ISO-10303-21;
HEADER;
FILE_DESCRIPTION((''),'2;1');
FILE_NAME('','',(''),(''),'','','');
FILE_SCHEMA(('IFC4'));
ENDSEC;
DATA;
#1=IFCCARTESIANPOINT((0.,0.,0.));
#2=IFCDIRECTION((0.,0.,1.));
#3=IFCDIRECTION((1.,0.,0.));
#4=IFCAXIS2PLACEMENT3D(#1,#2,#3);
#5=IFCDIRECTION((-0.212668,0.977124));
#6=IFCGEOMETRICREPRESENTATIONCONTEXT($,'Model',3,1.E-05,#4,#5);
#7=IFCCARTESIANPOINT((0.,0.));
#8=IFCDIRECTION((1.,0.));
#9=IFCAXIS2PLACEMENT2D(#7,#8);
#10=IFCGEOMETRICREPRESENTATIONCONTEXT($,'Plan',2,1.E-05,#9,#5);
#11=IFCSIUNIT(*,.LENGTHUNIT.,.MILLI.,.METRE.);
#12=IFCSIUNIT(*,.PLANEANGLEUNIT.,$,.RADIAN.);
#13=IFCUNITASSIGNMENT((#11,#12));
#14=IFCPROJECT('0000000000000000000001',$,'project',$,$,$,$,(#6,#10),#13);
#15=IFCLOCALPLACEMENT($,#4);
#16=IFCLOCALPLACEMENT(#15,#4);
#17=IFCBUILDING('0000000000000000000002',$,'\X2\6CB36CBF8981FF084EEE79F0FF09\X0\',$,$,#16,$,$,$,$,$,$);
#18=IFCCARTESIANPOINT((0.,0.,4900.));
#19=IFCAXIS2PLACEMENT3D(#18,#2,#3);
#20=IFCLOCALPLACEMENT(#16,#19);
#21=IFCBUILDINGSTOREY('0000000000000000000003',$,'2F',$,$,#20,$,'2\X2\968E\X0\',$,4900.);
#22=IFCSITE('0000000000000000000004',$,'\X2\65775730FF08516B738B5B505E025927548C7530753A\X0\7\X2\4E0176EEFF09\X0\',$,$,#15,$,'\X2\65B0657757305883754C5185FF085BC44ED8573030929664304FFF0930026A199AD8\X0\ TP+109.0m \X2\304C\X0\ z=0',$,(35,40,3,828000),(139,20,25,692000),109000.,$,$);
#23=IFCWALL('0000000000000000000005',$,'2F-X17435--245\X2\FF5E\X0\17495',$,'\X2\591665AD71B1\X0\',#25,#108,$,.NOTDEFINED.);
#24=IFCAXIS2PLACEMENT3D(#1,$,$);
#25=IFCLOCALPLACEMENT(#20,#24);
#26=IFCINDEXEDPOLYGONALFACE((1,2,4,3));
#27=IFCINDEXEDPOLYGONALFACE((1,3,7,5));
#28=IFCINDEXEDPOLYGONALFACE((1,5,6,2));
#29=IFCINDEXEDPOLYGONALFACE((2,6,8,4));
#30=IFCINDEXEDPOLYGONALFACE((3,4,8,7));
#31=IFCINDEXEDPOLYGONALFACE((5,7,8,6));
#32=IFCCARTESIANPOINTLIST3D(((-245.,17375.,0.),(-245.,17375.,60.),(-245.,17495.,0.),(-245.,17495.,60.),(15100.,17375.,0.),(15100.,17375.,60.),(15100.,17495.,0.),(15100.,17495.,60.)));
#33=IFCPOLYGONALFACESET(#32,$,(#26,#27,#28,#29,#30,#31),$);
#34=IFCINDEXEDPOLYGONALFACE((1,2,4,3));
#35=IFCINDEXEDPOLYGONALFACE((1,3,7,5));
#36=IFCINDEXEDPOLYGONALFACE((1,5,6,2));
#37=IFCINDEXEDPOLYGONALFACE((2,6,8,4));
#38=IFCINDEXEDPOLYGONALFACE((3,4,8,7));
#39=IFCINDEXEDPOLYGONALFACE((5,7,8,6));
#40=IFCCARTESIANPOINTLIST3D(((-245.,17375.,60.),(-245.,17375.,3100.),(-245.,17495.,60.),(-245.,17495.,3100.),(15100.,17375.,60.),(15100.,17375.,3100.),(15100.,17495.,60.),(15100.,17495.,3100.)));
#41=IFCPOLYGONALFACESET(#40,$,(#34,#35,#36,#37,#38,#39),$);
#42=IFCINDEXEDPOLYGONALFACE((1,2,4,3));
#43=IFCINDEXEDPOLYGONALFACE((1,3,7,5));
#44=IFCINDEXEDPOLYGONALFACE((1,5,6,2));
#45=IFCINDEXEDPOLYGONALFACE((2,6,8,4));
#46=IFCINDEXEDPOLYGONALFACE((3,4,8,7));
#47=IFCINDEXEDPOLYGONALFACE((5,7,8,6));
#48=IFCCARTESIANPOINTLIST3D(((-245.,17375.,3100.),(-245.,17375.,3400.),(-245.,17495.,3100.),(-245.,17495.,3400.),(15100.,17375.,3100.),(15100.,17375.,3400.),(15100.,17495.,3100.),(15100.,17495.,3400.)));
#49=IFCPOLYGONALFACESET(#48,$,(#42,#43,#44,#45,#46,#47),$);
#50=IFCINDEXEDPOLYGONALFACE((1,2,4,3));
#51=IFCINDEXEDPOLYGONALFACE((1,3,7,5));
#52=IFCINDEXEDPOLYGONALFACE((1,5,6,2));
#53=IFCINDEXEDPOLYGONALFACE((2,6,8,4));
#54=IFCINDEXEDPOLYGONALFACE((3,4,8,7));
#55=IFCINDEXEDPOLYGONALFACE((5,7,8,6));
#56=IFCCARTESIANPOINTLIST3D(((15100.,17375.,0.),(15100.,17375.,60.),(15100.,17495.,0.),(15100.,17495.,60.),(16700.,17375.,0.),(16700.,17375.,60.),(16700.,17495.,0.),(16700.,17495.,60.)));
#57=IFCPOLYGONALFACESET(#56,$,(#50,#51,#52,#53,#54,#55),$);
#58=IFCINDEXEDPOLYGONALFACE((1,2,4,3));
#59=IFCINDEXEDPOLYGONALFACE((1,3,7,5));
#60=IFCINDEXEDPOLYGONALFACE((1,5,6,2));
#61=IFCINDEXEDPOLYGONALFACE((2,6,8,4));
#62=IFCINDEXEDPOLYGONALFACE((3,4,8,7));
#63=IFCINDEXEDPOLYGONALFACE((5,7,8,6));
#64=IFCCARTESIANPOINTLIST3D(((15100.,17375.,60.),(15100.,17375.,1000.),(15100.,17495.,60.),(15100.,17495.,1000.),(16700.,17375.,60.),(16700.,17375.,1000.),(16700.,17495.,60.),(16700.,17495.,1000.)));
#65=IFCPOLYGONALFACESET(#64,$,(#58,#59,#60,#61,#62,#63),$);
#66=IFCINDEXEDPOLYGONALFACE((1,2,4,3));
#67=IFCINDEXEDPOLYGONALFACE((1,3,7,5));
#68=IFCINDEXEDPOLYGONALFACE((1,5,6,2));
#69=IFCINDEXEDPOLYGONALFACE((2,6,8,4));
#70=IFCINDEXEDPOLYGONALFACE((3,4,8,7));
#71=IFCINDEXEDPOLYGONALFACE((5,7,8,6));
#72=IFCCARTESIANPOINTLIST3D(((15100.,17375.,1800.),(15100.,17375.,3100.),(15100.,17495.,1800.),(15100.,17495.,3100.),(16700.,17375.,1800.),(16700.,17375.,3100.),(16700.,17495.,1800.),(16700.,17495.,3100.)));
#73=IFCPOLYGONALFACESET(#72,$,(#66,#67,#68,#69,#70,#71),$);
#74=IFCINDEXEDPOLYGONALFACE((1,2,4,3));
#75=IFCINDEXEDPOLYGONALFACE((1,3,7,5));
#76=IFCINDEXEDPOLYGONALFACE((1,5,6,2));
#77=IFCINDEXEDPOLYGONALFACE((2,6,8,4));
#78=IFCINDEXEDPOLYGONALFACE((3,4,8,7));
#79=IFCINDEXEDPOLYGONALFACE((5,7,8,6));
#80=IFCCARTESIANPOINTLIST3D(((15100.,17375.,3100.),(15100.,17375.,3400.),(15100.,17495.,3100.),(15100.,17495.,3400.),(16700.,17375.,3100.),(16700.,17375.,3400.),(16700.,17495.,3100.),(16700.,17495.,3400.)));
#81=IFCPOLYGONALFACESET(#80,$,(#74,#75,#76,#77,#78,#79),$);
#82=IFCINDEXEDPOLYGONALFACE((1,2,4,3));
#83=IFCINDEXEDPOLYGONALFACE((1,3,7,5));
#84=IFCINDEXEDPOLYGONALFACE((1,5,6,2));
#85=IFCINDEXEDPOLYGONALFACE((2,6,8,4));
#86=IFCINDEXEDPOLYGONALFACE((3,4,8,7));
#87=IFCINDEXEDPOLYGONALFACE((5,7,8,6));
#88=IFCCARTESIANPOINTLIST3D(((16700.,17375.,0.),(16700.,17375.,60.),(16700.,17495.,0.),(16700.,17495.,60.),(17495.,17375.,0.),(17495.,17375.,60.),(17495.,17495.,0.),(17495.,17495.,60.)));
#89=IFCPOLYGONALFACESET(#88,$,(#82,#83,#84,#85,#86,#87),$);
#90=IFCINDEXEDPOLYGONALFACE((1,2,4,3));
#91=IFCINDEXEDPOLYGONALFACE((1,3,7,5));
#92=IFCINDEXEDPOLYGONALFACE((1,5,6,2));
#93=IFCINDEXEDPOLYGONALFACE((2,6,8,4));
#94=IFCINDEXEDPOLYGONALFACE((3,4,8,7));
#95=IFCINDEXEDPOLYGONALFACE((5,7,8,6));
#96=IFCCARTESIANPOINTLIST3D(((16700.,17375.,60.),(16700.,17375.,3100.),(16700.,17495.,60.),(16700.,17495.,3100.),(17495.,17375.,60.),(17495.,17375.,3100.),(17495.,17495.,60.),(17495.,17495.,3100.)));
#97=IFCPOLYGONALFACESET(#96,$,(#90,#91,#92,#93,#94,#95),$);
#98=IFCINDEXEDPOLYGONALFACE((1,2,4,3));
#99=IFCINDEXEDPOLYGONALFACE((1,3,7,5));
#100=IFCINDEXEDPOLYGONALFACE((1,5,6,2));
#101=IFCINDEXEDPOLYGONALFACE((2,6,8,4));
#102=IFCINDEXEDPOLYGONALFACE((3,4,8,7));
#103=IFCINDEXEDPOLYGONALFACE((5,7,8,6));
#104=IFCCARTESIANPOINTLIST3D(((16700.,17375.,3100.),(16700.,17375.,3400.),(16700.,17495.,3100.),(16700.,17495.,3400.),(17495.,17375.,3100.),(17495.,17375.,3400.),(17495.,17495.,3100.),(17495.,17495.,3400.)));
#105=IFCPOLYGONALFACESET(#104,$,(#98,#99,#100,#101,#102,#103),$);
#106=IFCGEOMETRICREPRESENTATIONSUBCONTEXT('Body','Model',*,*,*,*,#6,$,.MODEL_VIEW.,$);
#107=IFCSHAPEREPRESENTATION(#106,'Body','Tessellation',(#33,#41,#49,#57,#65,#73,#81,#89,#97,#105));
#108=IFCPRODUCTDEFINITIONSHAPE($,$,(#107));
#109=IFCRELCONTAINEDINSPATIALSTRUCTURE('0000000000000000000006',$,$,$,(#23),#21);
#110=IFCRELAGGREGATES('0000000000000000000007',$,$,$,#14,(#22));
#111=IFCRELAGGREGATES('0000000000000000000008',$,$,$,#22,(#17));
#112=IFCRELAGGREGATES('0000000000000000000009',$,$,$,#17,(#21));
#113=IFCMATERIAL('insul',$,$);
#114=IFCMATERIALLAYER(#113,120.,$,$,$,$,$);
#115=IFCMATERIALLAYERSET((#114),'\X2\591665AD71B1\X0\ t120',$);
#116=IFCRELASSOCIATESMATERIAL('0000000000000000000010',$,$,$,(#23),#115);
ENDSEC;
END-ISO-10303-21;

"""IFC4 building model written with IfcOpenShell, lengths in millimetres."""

from ifc_helpers import new_model, si_unit, direction, frame, frame_2d, origin, origin_with_axes, origin_2d_with_axis, place, context, subcontext, project, spatial, rectangle, extrude, material, layer, layer_set, layer_usage, element, save


model = new_model("IFC4")

# Units and contexts
model_context = context("Model", 3, precision=1e-05, world=origin_with_axes(), true_north=direction((-0.212668, 0.977124)))
plan_context = context("Plan", 2, precision=1e-05, world=origin_2d_with_axis(), true_north=direction((-0.212668, 0.977124)))
body_context = subcontext(model_context, "Body", "Model", "MODEL_VIEW")
ifc_project = project(units=[si_unit("LENGTHUNIT", "METRE", prefix="MILLI"), si_unit("PLANEANGLEUNIT", "RADIAN")], contexts=[model_context, plan_context])

# Site, building, storey
site_placement = place(None, origin_with_axes())
site = spatial("IfcSite", under=ifc_project, at=site_placement, Name="敷地（八王子市大和田町7丁目）", LongName="新敷地境界内（寄付地を除く）。標高 TP+109.0m が z=0", RefLatitude=(35, 40, 3, 828000), RefLongitude=(139, 20, 25, 692000), RefElevation=109000.0)
building_placement = place(site_placement, origin_with_axes())
building = spatial("IfcBuilding", under=site, at=building_placement, Name="河沿要（仮称）")
storey_placement = place(building_placement, frame((0.0, 0.0, 4900.0), z_axis=(0.0, 0.0, 1.0), x_axis=(1.0, 0.0, 0.0)))
storey = spatial("IfcBuildingStorey", under=building, at=storey_placement, Name="2F", LongName="2階", Elevation=4900.0)

# Wall
ifc_material_1 = material(Name="insul")
ifc_layer_1 = layer(ifc_material_1, 120.0)
ifc_layer_set_1 = layer_set([ifc_layer_1], Name="外断熱 t120")
ifc_layer_usage_1 = layer_usage(ifc_layer_set_1, "AXIS2", "POSITIVE", 0.0)
wall_1_placement = place(storey_placement, origin_with_axes())
element("IfcWall", 1, at=wall_1_placement, inside=storey, material=ifc_layer_usage_1, Name="2F-X17435--245～17495", ObjectType="外断熱", PredefinedType="NOTDEFINED", context=body_context, shape_type="SweptSolid", body=[
    extrude(rectangle(XDim=15345.0, YDim=120.0, at=frame_2d((7427.5, 17435.0))), origin(), (0.0, 0.0, 1.0), 60.0),
    extrude(rectangle(XDim=15345.0, YDim=120.0, at=frame_2d((7427.5, 17435.0))), frame((0.0, 0.0, 60.0)), (0.0, 0.0, 1.0), 3040.0),
    extrude(rectangle(XDim=15345.0, YDim=120.0, at=frame_2d((7427.5, 17435.0))), frame((0.0, 0.0, 3100.0)), (0.0, 0.0, 1.0), 300.0),
    extrude(rectangle(XDim=1600.0, YDim=120.0, at=frame_2d((15900.0, 17435.0))), origin(), (0.0, 0.0, 1.0), 60.0),
    extrude(rectangle(XDim=1600.0, YDim=120.0, at=frame_2d((15900.0, 17435.0))), frame((0.0, 0.0, 60.0)), (0.0, 0.0, 1.0), 940.0),
    extrude(rectangle(XDim=1600.0, YDim=120.0, at=frame_2d((15900.0, 17435.0))), frame((0.0, 0.0, 1800.0)), (0.0, 0.0, 1.0), 1300.0),
    extrude(rectangle(XDim=1600.0, YDim=120.0, at=frame_2d((15900.0, 17435.0))), frame((0.0, 0.0, 3100.0)), (0.0, 0.0, 1.0), 300.0),
    extrude(rectangle(XDim=795.0, YDim=120.0, at=frame_2d((17097.5, 17435.0))), origin(), (0.0, 0.0, 1.0), 60.0),
    extrude(rectangle(XDim=795.0, YDim=120.0, at=frame_2d((17097.5, 17435.0))), frame((0.0, 0.0, 60.0)), (0.0, 0.0, 1.0), 3040.0),
    extrude(rectangle(XDim=795.0, YDim=120.0, at=frame_2d((17097.5, 17435.0))), frame((0.0, 0.0, 3100.0)), (0.0, 0.0, 1.0), 300.0),
])

save(model, "model.ifc")
